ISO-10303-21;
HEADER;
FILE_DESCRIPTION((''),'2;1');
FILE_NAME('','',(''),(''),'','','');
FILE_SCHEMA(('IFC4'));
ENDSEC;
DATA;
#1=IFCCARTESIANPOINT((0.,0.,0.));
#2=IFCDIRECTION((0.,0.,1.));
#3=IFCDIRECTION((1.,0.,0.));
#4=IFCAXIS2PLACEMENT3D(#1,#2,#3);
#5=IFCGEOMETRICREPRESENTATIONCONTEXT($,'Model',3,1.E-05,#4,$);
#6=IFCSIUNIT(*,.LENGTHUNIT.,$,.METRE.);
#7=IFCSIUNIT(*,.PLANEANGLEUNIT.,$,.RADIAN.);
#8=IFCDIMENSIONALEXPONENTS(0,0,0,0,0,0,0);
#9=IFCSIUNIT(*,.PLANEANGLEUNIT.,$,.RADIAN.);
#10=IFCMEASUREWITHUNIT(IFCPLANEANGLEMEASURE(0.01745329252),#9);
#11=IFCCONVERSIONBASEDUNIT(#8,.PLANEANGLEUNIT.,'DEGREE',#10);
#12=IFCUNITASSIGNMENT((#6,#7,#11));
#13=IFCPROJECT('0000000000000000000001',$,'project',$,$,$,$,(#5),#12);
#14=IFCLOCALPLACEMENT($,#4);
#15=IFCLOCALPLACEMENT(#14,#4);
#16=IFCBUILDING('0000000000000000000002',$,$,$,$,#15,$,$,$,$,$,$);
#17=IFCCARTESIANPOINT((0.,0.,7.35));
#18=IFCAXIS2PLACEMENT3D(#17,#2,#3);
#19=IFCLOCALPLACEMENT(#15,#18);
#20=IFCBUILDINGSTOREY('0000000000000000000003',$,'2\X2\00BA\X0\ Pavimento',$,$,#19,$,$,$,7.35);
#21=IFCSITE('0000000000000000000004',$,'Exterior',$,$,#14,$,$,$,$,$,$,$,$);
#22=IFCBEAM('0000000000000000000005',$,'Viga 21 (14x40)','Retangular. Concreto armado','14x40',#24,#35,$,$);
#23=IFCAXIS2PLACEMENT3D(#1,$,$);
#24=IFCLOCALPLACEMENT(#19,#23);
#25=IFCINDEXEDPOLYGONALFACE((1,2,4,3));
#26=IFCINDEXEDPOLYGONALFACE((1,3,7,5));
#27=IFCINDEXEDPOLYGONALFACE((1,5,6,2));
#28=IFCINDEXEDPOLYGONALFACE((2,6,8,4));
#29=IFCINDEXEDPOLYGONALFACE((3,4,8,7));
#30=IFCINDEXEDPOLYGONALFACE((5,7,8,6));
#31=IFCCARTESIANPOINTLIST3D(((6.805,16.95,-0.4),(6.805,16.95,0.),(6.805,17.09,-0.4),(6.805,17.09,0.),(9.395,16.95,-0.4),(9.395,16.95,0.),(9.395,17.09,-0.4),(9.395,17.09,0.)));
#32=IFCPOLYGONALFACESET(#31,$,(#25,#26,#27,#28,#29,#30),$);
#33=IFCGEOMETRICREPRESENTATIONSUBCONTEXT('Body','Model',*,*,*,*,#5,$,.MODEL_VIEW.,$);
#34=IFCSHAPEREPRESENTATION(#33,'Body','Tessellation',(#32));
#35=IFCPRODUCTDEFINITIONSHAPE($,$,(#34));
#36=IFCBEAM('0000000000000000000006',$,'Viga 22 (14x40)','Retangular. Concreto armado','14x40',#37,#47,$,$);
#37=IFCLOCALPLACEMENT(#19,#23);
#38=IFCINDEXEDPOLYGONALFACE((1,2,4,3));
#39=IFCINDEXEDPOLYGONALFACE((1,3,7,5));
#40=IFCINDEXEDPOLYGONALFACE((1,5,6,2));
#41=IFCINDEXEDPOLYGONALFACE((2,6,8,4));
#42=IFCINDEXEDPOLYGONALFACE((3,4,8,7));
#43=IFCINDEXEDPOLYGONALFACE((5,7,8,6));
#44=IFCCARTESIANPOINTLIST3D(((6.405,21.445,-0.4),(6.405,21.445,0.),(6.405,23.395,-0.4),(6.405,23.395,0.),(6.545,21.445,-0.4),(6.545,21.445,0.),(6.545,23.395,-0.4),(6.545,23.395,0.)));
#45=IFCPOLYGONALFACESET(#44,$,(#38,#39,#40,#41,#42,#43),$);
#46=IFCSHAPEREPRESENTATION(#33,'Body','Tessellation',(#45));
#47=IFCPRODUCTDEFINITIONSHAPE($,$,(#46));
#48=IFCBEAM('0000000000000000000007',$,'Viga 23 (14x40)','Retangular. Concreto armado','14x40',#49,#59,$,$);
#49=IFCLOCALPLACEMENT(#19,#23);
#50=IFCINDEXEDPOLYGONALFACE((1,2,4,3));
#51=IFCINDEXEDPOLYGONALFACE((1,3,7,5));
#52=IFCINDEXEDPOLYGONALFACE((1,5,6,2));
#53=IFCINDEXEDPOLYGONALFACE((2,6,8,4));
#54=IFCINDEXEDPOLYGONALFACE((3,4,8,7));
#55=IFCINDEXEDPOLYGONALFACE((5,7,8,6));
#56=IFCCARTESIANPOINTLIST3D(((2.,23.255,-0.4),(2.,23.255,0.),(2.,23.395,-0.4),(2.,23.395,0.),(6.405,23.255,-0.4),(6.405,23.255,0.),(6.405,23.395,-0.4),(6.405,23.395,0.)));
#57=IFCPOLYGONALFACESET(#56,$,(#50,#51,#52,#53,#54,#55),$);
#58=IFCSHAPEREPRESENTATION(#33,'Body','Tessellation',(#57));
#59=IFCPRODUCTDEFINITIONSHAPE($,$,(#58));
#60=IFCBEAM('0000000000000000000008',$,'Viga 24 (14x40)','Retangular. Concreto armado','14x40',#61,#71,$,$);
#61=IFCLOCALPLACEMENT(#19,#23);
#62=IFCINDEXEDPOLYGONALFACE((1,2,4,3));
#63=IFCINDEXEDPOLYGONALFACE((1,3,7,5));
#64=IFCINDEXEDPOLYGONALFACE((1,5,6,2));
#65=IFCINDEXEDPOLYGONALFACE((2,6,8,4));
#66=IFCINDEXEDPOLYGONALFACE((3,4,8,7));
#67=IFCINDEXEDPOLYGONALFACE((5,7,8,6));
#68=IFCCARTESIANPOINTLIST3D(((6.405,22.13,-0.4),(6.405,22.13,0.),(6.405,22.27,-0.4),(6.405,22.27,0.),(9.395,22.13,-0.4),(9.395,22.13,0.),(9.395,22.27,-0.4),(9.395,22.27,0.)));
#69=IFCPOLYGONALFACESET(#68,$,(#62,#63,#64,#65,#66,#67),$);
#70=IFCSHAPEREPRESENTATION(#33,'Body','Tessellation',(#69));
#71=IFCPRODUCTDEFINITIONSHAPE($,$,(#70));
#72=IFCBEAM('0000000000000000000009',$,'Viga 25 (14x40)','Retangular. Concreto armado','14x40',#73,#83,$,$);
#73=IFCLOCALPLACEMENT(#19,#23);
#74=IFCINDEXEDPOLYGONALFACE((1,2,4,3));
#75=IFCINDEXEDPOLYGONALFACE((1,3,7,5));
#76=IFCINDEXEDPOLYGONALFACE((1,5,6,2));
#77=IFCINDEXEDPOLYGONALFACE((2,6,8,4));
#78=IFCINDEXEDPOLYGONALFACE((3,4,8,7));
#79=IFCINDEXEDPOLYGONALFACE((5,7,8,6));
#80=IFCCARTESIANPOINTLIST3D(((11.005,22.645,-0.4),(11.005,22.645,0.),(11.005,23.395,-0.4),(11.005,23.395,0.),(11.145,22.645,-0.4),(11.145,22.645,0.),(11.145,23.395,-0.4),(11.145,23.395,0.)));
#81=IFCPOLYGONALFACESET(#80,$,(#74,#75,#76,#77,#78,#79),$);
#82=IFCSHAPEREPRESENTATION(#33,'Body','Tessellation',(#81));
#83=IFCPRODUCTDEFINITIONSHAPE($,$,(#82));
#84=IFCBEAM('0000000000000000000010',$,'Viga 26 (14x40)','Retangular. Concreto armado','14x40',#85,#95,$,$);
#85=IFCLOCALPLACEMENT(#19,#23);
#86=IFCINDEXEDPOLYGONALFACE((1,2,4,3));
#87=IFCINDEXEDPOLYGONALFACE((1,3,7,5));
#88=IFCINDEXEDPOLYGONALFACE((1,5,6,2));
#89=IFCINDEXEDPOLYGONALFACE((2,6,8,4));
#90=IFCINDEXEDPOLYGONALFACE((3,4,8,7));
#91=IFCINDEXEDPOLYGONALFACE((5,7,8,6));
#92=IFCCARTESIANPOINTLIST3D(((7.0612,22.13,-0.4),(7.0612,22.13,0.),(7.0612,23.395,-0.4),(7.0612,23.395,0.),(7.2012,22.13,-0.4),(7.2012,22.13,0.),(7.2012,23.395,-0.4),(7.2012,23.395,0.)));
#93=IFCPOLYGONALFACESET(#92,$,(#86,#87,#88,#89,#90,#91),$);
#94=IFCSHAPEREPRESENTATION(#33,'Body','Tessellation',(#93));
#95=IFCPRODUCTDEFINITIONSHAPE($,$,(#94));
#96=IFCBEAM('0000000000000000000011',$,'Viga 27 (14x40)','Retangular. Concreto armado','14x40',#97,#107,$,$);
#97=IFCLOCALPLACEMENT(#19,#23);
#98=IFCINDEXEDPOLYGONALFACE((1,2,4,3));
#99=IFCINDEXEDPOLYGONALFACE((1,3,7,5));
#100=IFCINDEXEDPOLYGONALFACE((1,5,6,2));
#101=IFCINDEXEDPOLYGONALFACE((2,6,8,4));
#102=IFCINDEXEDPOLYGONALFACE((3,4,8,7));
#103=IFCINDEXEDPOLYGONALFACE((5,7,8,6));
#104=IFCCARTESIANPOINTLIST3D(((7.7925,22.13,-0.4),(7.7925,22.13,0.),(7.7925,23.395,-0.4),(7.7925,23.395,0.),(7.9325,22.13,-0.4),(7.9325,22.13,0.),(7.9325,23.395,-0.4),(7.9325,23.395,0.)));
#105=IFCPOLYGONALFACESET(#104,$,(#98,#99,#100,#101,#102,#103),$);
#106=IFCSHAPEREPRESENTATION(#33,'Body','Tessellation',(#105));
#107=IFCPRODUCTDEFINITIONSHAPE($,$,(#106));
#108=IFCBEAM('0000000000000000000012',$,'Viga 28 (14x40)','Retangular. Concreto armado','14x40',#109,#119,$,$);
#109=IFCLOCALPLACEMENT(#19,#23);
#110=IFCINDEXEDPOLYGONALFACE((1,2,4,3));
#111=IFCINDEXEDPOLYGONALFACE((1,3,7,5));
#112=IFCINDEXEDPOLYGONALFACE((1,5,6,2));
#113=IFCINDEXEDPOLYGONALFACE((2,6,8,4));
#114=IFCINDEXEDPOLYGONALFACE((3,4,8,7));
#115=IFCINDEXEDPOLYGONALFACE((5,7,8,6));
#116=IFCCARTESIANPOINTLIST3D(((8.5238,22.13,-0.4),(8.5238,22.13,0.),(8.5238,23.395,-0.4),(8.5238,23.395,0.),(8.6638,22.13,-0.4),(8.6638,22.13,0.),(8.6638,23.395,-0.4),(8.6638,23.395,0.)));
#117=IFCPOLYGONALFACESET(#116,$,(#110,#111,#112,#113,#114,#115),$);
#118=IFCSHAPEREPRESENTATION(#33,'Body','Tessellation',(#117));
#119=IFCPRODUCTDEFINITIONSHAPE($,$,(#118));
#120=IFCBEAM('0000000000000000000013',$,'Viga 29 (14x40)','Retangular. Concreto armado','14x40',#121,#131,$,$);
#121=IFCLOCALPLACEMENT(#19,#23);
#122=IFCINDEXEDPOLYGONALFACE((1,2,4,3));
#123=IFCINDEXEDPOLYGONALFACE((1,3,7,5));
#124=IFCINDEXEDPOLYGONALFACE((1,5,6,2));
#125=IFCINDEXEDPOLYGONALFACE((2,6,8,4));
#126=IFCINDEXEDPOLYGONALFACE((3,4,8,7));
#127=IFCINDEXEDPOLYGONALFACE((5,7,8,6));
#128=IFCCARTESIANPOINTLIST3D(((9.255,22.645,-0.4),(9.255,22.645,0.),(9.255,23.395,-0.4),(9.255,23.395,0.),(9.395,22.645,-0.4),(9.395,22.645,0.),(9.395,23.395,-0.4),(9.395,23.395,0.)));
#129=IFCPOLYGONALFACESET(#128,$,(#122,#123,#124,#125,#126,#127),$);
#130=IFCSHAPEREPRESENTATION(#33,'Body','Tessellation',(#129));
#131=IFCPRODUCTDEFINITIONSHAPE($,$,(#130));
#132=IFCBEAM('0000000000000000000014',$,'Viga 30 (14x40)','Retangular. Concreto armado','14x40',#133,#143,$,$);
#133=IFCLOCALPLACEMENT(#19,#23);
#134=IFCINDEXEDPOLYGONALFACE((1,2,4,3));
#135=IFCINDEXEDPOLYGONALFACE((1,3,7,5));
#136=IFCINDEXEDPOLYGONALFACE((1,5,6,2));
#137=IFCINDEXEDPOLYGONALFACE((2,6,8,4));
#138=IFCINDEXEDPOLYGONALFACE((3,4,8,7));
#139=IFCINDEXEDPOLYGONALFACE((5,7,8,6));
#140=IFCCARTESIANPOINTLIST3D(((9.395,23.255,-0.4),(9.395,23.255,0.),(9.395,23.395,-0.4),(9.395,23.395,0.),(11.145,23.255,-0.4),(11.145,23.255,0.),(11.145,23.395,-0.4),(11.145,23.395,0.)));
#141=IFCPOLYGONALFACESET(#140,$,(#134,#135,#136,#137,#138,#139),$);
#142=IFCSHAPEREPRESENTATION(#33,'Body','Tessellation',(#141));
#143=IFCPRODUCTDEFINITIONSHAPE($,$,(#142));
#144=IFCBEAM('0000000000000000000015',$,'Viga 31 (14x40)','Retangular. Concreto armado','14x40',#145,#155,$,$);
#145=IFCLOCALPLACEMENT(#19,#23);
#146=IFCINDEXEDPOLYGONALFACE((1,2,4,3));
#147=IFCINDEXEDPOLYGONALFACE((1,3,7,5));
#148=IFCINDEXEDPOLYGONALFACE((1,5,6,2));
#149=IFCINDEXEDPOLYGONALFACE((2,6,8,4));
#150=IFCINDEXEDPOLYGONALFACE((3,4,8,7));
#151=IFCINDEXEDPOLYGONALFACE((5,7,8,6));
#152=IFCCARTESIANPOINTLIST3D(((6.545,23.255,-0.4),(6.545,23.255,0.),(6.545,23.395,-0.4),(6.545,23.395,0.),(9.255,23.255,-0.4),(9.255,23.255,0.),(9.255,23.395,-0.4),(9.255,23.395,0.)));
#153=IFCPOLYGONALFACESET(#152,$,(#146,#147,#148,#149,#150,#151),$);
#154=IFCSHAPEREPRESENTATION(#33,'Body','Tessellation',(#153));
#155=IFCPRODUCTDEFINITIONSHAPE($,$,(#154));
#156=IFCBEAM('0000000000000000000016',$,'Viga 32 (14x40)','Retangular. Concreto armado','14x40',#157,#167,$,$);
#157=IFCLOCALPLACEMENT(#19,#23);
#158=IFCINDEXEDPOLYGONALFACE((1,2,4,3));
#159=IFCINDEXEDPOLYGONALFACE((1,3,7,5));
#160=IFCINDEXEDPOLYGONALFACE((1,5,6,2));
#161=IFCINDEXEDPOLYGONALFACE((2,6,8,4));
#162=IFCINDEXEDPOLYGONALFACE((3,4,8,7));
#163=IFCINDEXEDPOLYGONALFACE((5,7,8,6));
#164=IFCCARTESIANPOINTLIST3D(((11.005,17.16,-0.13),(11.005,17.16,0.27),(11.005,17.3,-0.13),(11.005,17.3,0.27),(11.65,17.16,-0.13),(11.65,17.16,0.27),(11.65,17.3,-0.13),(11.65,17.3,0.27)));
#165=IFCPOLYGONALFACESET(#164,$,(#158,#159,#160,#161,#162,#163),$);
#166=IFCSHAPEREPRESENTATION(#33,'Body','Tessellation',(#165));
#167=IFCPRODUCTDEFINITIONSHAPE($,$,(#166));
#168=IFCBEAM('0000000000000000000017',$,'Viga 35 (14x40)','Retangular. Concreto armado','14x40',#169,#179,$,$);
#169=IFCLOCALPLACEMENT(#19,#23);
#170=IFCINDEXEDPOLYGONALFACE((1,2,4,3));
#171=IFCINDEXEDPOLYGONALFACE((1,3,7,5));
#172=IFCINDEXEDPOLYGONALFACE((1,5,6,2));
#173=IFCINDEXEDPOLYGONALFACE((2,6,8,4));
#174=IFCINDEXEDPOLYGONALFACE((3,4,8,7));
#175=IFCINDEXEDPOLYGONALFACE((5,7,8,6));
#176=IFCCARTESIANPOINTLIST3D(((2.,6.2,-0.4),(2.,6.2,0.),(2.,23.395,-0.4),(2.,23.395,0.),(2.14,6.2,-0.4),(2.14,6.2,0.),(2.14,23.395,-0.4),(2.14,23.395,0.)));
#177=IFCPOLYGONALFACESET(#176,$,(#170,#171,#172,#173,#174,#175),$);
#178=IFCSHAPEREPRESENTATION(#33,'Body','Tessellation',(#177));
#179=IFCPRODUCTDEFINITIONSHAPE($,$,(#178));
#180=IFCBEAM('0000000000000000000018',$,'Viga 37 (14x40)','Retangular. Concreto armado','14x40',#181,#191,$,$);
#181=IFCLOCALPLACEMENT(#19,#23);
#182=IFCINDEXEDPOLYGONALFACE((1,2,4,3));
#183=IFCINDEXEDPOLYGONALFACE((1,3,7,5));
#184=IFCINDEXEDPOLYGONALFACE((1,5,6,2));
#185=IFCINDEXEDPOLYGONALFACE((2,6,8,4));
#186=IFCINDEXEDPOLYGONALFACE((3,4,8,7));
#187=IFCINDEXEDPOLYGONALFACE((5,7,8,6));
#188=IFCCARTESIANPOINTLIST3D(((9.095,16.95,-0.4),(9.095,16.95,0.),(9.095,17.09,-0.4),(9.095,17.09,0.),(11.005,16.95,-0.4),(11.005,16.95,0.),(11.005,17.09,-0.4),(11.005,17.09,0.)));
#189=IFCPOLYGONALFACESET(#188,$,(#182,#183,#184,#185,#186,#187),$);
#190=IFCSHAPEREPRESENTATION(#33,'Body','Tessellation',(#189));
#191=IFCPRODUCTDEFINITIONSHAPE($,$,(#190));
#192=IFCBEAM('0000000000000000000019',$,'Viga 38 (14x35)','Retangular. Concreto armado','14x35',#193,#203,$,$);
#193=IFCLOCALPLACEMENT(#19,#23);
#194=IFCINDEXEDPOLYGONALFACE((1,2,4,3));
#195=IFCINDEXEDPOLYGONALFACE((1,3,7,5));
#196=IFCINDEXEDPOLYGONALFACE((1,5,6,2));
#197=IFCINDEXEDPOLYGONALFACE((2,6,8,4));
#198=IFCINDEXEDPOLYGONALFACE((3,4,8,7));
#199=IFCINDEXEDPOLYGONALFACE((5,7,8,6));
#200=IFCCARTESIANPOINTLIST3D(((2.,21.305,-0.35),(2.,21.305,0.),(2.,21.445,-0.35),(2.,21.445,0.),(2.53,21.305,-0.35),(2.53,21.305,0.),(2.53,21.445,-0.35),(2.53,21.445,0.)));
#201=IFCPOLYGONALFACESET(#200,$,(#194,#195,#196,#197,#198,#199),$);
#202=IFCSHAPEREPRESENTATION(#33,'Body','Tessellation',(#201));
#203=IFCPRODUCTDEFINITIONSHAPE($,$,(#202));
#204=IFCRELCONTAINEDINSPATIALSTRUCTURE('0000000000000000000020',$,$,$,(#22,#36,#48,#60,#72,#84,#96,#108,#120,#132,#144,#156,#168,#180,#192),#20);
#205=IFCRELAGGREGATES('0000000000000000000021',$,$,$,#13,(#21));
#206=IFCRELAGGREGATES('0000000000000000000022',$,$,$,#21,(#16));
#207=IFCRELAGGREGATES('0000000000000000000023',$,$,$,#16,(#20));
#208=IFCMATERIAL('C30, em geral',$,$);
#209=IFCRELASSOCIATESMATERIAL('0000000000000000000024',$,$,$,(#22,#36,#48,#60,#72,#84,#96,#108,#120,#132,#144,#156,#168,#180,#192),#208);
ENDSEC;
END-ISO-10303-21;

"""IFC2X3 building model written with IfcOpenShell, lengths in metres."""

from ifc_helpers import new_model, entity, si_unit, converted_unit, frame, frame_2d, origin_with_axes, place, context, subcontext, project, spatial, rectangle, extrude, material, element, save


model = new_model("IFC2X3")

# Units and contexts
model_context = context("Model", 3, precision=1e-05, world=origin_with_axes())
body_context = subcontext(model_context, "Body", "Model", "MODEL_VIEW")
ifc_project = project(units=[si_unit("LENGTHUNIT", "METRE"), si_unit("PLANEANGLEUNIT", "RADIAN"), converted_unit("PLANEANGLEUNIT", "DEGREE", entity("IfcPlaneAngleMeasure", 0.01745329252), si_unit("PLANEANGLEUNIT", "RADIAN"), dimensions=[0, 0, 0, 0, 0, 0, 0])], contexts=[model_context])

# Site, building, storey
site_placement = place(None, origin_with_axes())
site = spatial("IfcSite", under=ifc_project, at=site_placement, Name="Exterior")
building_placement = place(site_placement, origin_with_axes())
building = spatial("IfcBuilding", under=site, at=building_placement)
storey_placement = place(building_placement, frame((0.0, 0.0, 7.35), z_axis=(0.0, 0.0, 1.0), x_axis=(1.0, 0.0, 0.0)))
storey = spatial("IfcBuildingStorey", under=building, at=storey_placement, Name="2º Pavimento", Elevation=7.35)

# Beams
ifc_material_1 = material(Name="C30, em geral")
beam_1_placement = place(storey_placement, frame((6.805, 17.02, 0.0), z_axis=(1.0, 0.0, 0.0), x_axis=(0.0, 1.0, 0.0)))
element("IfcBeam", 1, at=beam_1_placement, inside=storey, material=ifc_material_1, Name="Viga 21 (14x40)", Description="Retangular. Concreto armado", ObjectType="14x40", context=body_context, shape_type="SweptSolid", body=[
    extrude(rectangle(XDim=0.14, YDim=0.4, at=frame_2d((0.0, -0.2), x_axis=(1.0, 0.0))), origin_with_axes(), (0.0, 0.0, 1.0), 2.59),
])
beam_2_placement = place(storey_placement, frame((6.475, 21.445, 0.0), z_axis=(0.0, 1.0, 0.0), x_axis=(-1.0, 0.0, 0.0)))
element("IfcBeam", 2, at=beam_2_placement, inside=storey, material=ifc_material_1, Name="Viga 22 (14x40)", Description="Retangular. Concreto armado", ObjectType="14x40", context=body_context, shape_type="SweptSolid", body=[
    extrude(rectangle(XDim=0.14, YDim=0.4, at=frame_2d((0.0, -0.2), x_axis=(1.0, 0.0))), origin_with_axes(), (0.0, 0.0, 1.0), 1.95),
])
beam_3_placement = place(storey_placement, frame((2.0, 23.325, 0.0), z_axis=(1.0, 0.0, 0.0), x_axis=(0.0, 1.0, 0.0)))
element("IfcBeam", 3, at=beam_3_placement, inside=storey, material=ifc_material_1, Name="Viga 23 (14x40)", Description="Retangular. Concreto armado", ObjectType="14x40", context=body_context, shape_type="SweptSolid", body=[
    extrude(rectangle(XDim=0.14, YDim=0.4, at=frame_2d((0.0, -0.2), x_axis=(1.0, 0.0))), origin_with_axes(), (0.0, 0.0, 1.0), 4.405),
])
beam_4_placement = place(storey_placement, frame((6.405, 22.2, 0.0), z_axis=(1.0, 0.0, 0.0), x_axis=(0.0, 1.0, 0.0)))
element("IfcBeam", 4, at=beam_4_placement, inside=storey, material=ifc_material_1, Name="Viga 24 (14x40)", Description="Retangular. Concreto armado", ObjectType="14x40", context=body_context, shape_type="SweptSolid", body=[
    extrude(rectangle(XDim=0.14, YDim=0.4, at=frame_2d((0.0, -0.2), x_axis=(1.0, 0.0))), origin_with_axes(), (0.0, 0.0, 1.0), 2.99),
])
beam_5_placement = place(storey_placement, frame((11.075, 22.645, 0.0), z_axis=(0.0, 1.0, 0.0), x_axis=(-1.0, 0.0, 0.0)))
element("IfcBeam", 5, at=beam_5_placement, inside=storey, material=ifc_material_1, Name="Viga 25 (14x40)", Description="Retangular. Concreto armado", ObjectType="14x40", context=body_context, shape_type="SweptSolid", body=[
    extrude(rectangle(XDim=0.14, YDim=0.4, at=frame_2d((0.0, -0.2), x_axis=(1.0, 0.0))), origin_with_axes(), (0.0, 0.0, 1.0), 0.75),
])
beam_6_placement = place(storey_placement, frame((7.1312, 23.395, 0.0), z_axis=(0.0, -1.0, 0.0), x_axis=(1.0, 0.0, 0.0)))
element("IfcBeam", 6, at=beam_6_placement, inside=storey, material=ifc_material_1, Name="Viga 26 (14x40)", Description="Retangular. Concreto armado", ObjectType="14x40", context=body_context, shape_type="SweptSolid", body=[
    extrude(rectangle(XDim=0.14, YDim=0.4, at=frame_2d((0.0, -0.2), x_axis=(1.0, 0.0))), origin_with_axes(), (0.0, 0.0, 1.0), 1.265),
])
beam_7_placement = place(storey_placement, frame((7.8625, 23.395, 0.0), z_axis=(0.0, -1.0, 0.0), x_axis=(1.0, 0.0, 0.0)))
element("IfcBeam", 7, at=beam_7_placement, inside=storey, material=ifc_material_1, Name="Viga 27 (14x40)", Description="Retangular. Concreto armado", ObjectType="14x40", context=body_context, shape_type="SweptSolid", body=[
    extrude(rectangle(XDim=0.14, YDim=0.4, at=frame_2d((0.0, -0.2), x_axis=(1.0, 0.0))), origin_with_axes(), (0.0, 0.0, 1.0), 1.265),
])
beam_8_placement = place(storey_placement, frame((8.5938, 23.395, 0.0), z_axis=(0.0, -1.0, 0.0), x_axis=(1.0, 0.0, 0.0)))
element("IfcBeam", 8, at=beam_8_placement, inside=storey, material=ifc_material_1, Name="Viga 28 (14x40)", Description="Retangular. Concreto armado", ObjectType="14x40", context=body_context, shape_type="SweptSolid", body=[
    extrude(rectangle(XDim=0.14, YDim=0.4, at=frame_2d((0.0, -0.2), x_axis=(1.0, 0.0))), origin_with_axes(), (0.0, 0.0, 1.0), 1.265),
])
beam_9_placement = place(storey_placement, frame((9.325, 22.645, 0.0), z_axis=(0.0, 1.0, 0.0), x_axis=(-1.0, 0.0, 0.0)))
element("IfcBeam", 9, at=beam_9_placement, inside=storey, material=ifc_material_1, Name="Viga 29 (14x40)", Description="Retangular. Concreto armado", ObjectType="14x40", context=body_context, shape_type="SweptSolid", body=[
    extrude(rectangle(XDim=0.14, YDim=0.4, at=frame_2d((0.0, -0.2), x_axis=(1.0, 0.0))), origin_with_axes(), (0.0, 0.0, 1.0), 0.75),
])
beam_10_placement = place(storey_placement, frame((11.145, 23.325, 0.0), z_axis=(-1.0, 0.0, 0.0), x_axis=(0.0, -1.0, 0.0)))
element("IfcBeam", 10, at=beam_10_placement, inside=storey, material=ifc_material_1, Name="Viga 30 (14x40)", Description="Retangular. Concreto armado", ObjectType="14x40", context=body_context, shape_type="SweptSolid", body=[
    extrude(rectangle(XDim=0.14, YDim=0.4, at=frame_2d((0.0, -0.2), x_axis=(1.0, 0.0))), origin_with_axes(), (0.0, 0.0, 1.0), 1.75),
])
beam_11_placement = place(storey_placement, frame((9.255, 23.325, 0.0), z_axis=(-1.0, 0.0, 0.0), x_axis=(0.0, -1.0, 0.0)))
element("IfcBeam", 11, at=beam_11_placement, inside=storey, material=ifc_material_1, Name="Viga 31 (14x40)", Description="Retangular. Concreto armado", ObjectType="14x40", context=body_context, shape_type="SweptSolid", body=[
    extrude(rectangle(XDim=0.14, YDim=0.4, at=frame_2d((0.0, -0.2), x_axis=(1.0, 0.0))), origin_with_axes(), (0.0, 0.0, 1.0), 2.71),
])
beam_12_placement = place(storey_placement, frame((11.005, 17.23, 0.27), z_axis=(1.0, 0.0, 0.0), x_axis=(0.0, 1.0, 0.0)))
element("IfcBeam", 12, at=beam_12_placement, inside=storey, material=ifc_material_1, Name="Viga 32 (14x40)", Description="Retangular. Concreto armado", ObjectType="14x40", context=body_context, shape_type="SweptSolid", body=[
    extrude(rectangle(XDim=0.14, YDim=0.4, at=frame_2d((0.0, -0.2), x_axis=(1.0, 0.0))), origin_with_axes(), (0.0, 0.0, 1.0), 0.645),
])
beam_13_placement = place(storey_placement, frame((2.07, 23.395, 0.0), z_axis=(0.0, -1.0, 0.0), x_axis=(1.0, 0.0, 0.0)))
element("IfcBeam", 13, at=beam_13_placement, inside=storey, material=ifc_material_1, Name="Viga 35 (14x40)", Description="Retangular. Concreto armado", ObjectType="14x40", context=body_context, shape_type="SweptSolid", body=[
    extrude(rectangle(XDim=0.14, YDim=0.4, at=frame_2d((0.0, -0.2), x_axis=(1.0, 0.0))), origin_with_axes(), (0.0, 0.0, 1.0), 17.195),
])
beam_14_placement = place(storey_placement, frame((9.095, 17.02, 0.0), z_axis=(1.0, 0.0, 0.0), x_axis=(0.0, 1.0, 0.0)))
element("IfcBeam", 14, at=beam_14_placement, inside=storey, material=ifc_material_1, Name="Viga 37 (14x40)", Description="Retangular. Concreto armado", ObjectType="14x40", context=body_context, shape_type="SweptSolid", body=[
    extrude(rectangle(XDim=0.14, YDim=0.4, at=frame_2d((0.0, -0.2), x_axis=(1.0, 0.0))), origin_with_axes(), (0.0, 0.0, 1.0), 1.91),
])
for number, where, z_axis, x_axis, name in (
    (15, (2.0, 21.375, 0.0), (1.0, 0.0, 0.0), (0.0, 1.0, 0.0), "Viga 38 (14x35)"),
):
    element("IfcBeam", number, at=place(storey_placement, frame(where, z_axis=z_axis, x_axis=x_axis)), inside=storey, material=ifc_material_1, Name=name, Description="Retangular. Concreto armado", ObjectType="14x35", context=body_context, shape_type="SweptSolid", body=[
        extrude(rectangle(XDim=0.14, YDim=0.35, at=frame_2d((0.0, -0.175), x_axis=(1.0, 0.0))), origin_with_axes(), (0.0, 0.0, 1.0), 0.53),
    ])

save(model, "model.ifc")
